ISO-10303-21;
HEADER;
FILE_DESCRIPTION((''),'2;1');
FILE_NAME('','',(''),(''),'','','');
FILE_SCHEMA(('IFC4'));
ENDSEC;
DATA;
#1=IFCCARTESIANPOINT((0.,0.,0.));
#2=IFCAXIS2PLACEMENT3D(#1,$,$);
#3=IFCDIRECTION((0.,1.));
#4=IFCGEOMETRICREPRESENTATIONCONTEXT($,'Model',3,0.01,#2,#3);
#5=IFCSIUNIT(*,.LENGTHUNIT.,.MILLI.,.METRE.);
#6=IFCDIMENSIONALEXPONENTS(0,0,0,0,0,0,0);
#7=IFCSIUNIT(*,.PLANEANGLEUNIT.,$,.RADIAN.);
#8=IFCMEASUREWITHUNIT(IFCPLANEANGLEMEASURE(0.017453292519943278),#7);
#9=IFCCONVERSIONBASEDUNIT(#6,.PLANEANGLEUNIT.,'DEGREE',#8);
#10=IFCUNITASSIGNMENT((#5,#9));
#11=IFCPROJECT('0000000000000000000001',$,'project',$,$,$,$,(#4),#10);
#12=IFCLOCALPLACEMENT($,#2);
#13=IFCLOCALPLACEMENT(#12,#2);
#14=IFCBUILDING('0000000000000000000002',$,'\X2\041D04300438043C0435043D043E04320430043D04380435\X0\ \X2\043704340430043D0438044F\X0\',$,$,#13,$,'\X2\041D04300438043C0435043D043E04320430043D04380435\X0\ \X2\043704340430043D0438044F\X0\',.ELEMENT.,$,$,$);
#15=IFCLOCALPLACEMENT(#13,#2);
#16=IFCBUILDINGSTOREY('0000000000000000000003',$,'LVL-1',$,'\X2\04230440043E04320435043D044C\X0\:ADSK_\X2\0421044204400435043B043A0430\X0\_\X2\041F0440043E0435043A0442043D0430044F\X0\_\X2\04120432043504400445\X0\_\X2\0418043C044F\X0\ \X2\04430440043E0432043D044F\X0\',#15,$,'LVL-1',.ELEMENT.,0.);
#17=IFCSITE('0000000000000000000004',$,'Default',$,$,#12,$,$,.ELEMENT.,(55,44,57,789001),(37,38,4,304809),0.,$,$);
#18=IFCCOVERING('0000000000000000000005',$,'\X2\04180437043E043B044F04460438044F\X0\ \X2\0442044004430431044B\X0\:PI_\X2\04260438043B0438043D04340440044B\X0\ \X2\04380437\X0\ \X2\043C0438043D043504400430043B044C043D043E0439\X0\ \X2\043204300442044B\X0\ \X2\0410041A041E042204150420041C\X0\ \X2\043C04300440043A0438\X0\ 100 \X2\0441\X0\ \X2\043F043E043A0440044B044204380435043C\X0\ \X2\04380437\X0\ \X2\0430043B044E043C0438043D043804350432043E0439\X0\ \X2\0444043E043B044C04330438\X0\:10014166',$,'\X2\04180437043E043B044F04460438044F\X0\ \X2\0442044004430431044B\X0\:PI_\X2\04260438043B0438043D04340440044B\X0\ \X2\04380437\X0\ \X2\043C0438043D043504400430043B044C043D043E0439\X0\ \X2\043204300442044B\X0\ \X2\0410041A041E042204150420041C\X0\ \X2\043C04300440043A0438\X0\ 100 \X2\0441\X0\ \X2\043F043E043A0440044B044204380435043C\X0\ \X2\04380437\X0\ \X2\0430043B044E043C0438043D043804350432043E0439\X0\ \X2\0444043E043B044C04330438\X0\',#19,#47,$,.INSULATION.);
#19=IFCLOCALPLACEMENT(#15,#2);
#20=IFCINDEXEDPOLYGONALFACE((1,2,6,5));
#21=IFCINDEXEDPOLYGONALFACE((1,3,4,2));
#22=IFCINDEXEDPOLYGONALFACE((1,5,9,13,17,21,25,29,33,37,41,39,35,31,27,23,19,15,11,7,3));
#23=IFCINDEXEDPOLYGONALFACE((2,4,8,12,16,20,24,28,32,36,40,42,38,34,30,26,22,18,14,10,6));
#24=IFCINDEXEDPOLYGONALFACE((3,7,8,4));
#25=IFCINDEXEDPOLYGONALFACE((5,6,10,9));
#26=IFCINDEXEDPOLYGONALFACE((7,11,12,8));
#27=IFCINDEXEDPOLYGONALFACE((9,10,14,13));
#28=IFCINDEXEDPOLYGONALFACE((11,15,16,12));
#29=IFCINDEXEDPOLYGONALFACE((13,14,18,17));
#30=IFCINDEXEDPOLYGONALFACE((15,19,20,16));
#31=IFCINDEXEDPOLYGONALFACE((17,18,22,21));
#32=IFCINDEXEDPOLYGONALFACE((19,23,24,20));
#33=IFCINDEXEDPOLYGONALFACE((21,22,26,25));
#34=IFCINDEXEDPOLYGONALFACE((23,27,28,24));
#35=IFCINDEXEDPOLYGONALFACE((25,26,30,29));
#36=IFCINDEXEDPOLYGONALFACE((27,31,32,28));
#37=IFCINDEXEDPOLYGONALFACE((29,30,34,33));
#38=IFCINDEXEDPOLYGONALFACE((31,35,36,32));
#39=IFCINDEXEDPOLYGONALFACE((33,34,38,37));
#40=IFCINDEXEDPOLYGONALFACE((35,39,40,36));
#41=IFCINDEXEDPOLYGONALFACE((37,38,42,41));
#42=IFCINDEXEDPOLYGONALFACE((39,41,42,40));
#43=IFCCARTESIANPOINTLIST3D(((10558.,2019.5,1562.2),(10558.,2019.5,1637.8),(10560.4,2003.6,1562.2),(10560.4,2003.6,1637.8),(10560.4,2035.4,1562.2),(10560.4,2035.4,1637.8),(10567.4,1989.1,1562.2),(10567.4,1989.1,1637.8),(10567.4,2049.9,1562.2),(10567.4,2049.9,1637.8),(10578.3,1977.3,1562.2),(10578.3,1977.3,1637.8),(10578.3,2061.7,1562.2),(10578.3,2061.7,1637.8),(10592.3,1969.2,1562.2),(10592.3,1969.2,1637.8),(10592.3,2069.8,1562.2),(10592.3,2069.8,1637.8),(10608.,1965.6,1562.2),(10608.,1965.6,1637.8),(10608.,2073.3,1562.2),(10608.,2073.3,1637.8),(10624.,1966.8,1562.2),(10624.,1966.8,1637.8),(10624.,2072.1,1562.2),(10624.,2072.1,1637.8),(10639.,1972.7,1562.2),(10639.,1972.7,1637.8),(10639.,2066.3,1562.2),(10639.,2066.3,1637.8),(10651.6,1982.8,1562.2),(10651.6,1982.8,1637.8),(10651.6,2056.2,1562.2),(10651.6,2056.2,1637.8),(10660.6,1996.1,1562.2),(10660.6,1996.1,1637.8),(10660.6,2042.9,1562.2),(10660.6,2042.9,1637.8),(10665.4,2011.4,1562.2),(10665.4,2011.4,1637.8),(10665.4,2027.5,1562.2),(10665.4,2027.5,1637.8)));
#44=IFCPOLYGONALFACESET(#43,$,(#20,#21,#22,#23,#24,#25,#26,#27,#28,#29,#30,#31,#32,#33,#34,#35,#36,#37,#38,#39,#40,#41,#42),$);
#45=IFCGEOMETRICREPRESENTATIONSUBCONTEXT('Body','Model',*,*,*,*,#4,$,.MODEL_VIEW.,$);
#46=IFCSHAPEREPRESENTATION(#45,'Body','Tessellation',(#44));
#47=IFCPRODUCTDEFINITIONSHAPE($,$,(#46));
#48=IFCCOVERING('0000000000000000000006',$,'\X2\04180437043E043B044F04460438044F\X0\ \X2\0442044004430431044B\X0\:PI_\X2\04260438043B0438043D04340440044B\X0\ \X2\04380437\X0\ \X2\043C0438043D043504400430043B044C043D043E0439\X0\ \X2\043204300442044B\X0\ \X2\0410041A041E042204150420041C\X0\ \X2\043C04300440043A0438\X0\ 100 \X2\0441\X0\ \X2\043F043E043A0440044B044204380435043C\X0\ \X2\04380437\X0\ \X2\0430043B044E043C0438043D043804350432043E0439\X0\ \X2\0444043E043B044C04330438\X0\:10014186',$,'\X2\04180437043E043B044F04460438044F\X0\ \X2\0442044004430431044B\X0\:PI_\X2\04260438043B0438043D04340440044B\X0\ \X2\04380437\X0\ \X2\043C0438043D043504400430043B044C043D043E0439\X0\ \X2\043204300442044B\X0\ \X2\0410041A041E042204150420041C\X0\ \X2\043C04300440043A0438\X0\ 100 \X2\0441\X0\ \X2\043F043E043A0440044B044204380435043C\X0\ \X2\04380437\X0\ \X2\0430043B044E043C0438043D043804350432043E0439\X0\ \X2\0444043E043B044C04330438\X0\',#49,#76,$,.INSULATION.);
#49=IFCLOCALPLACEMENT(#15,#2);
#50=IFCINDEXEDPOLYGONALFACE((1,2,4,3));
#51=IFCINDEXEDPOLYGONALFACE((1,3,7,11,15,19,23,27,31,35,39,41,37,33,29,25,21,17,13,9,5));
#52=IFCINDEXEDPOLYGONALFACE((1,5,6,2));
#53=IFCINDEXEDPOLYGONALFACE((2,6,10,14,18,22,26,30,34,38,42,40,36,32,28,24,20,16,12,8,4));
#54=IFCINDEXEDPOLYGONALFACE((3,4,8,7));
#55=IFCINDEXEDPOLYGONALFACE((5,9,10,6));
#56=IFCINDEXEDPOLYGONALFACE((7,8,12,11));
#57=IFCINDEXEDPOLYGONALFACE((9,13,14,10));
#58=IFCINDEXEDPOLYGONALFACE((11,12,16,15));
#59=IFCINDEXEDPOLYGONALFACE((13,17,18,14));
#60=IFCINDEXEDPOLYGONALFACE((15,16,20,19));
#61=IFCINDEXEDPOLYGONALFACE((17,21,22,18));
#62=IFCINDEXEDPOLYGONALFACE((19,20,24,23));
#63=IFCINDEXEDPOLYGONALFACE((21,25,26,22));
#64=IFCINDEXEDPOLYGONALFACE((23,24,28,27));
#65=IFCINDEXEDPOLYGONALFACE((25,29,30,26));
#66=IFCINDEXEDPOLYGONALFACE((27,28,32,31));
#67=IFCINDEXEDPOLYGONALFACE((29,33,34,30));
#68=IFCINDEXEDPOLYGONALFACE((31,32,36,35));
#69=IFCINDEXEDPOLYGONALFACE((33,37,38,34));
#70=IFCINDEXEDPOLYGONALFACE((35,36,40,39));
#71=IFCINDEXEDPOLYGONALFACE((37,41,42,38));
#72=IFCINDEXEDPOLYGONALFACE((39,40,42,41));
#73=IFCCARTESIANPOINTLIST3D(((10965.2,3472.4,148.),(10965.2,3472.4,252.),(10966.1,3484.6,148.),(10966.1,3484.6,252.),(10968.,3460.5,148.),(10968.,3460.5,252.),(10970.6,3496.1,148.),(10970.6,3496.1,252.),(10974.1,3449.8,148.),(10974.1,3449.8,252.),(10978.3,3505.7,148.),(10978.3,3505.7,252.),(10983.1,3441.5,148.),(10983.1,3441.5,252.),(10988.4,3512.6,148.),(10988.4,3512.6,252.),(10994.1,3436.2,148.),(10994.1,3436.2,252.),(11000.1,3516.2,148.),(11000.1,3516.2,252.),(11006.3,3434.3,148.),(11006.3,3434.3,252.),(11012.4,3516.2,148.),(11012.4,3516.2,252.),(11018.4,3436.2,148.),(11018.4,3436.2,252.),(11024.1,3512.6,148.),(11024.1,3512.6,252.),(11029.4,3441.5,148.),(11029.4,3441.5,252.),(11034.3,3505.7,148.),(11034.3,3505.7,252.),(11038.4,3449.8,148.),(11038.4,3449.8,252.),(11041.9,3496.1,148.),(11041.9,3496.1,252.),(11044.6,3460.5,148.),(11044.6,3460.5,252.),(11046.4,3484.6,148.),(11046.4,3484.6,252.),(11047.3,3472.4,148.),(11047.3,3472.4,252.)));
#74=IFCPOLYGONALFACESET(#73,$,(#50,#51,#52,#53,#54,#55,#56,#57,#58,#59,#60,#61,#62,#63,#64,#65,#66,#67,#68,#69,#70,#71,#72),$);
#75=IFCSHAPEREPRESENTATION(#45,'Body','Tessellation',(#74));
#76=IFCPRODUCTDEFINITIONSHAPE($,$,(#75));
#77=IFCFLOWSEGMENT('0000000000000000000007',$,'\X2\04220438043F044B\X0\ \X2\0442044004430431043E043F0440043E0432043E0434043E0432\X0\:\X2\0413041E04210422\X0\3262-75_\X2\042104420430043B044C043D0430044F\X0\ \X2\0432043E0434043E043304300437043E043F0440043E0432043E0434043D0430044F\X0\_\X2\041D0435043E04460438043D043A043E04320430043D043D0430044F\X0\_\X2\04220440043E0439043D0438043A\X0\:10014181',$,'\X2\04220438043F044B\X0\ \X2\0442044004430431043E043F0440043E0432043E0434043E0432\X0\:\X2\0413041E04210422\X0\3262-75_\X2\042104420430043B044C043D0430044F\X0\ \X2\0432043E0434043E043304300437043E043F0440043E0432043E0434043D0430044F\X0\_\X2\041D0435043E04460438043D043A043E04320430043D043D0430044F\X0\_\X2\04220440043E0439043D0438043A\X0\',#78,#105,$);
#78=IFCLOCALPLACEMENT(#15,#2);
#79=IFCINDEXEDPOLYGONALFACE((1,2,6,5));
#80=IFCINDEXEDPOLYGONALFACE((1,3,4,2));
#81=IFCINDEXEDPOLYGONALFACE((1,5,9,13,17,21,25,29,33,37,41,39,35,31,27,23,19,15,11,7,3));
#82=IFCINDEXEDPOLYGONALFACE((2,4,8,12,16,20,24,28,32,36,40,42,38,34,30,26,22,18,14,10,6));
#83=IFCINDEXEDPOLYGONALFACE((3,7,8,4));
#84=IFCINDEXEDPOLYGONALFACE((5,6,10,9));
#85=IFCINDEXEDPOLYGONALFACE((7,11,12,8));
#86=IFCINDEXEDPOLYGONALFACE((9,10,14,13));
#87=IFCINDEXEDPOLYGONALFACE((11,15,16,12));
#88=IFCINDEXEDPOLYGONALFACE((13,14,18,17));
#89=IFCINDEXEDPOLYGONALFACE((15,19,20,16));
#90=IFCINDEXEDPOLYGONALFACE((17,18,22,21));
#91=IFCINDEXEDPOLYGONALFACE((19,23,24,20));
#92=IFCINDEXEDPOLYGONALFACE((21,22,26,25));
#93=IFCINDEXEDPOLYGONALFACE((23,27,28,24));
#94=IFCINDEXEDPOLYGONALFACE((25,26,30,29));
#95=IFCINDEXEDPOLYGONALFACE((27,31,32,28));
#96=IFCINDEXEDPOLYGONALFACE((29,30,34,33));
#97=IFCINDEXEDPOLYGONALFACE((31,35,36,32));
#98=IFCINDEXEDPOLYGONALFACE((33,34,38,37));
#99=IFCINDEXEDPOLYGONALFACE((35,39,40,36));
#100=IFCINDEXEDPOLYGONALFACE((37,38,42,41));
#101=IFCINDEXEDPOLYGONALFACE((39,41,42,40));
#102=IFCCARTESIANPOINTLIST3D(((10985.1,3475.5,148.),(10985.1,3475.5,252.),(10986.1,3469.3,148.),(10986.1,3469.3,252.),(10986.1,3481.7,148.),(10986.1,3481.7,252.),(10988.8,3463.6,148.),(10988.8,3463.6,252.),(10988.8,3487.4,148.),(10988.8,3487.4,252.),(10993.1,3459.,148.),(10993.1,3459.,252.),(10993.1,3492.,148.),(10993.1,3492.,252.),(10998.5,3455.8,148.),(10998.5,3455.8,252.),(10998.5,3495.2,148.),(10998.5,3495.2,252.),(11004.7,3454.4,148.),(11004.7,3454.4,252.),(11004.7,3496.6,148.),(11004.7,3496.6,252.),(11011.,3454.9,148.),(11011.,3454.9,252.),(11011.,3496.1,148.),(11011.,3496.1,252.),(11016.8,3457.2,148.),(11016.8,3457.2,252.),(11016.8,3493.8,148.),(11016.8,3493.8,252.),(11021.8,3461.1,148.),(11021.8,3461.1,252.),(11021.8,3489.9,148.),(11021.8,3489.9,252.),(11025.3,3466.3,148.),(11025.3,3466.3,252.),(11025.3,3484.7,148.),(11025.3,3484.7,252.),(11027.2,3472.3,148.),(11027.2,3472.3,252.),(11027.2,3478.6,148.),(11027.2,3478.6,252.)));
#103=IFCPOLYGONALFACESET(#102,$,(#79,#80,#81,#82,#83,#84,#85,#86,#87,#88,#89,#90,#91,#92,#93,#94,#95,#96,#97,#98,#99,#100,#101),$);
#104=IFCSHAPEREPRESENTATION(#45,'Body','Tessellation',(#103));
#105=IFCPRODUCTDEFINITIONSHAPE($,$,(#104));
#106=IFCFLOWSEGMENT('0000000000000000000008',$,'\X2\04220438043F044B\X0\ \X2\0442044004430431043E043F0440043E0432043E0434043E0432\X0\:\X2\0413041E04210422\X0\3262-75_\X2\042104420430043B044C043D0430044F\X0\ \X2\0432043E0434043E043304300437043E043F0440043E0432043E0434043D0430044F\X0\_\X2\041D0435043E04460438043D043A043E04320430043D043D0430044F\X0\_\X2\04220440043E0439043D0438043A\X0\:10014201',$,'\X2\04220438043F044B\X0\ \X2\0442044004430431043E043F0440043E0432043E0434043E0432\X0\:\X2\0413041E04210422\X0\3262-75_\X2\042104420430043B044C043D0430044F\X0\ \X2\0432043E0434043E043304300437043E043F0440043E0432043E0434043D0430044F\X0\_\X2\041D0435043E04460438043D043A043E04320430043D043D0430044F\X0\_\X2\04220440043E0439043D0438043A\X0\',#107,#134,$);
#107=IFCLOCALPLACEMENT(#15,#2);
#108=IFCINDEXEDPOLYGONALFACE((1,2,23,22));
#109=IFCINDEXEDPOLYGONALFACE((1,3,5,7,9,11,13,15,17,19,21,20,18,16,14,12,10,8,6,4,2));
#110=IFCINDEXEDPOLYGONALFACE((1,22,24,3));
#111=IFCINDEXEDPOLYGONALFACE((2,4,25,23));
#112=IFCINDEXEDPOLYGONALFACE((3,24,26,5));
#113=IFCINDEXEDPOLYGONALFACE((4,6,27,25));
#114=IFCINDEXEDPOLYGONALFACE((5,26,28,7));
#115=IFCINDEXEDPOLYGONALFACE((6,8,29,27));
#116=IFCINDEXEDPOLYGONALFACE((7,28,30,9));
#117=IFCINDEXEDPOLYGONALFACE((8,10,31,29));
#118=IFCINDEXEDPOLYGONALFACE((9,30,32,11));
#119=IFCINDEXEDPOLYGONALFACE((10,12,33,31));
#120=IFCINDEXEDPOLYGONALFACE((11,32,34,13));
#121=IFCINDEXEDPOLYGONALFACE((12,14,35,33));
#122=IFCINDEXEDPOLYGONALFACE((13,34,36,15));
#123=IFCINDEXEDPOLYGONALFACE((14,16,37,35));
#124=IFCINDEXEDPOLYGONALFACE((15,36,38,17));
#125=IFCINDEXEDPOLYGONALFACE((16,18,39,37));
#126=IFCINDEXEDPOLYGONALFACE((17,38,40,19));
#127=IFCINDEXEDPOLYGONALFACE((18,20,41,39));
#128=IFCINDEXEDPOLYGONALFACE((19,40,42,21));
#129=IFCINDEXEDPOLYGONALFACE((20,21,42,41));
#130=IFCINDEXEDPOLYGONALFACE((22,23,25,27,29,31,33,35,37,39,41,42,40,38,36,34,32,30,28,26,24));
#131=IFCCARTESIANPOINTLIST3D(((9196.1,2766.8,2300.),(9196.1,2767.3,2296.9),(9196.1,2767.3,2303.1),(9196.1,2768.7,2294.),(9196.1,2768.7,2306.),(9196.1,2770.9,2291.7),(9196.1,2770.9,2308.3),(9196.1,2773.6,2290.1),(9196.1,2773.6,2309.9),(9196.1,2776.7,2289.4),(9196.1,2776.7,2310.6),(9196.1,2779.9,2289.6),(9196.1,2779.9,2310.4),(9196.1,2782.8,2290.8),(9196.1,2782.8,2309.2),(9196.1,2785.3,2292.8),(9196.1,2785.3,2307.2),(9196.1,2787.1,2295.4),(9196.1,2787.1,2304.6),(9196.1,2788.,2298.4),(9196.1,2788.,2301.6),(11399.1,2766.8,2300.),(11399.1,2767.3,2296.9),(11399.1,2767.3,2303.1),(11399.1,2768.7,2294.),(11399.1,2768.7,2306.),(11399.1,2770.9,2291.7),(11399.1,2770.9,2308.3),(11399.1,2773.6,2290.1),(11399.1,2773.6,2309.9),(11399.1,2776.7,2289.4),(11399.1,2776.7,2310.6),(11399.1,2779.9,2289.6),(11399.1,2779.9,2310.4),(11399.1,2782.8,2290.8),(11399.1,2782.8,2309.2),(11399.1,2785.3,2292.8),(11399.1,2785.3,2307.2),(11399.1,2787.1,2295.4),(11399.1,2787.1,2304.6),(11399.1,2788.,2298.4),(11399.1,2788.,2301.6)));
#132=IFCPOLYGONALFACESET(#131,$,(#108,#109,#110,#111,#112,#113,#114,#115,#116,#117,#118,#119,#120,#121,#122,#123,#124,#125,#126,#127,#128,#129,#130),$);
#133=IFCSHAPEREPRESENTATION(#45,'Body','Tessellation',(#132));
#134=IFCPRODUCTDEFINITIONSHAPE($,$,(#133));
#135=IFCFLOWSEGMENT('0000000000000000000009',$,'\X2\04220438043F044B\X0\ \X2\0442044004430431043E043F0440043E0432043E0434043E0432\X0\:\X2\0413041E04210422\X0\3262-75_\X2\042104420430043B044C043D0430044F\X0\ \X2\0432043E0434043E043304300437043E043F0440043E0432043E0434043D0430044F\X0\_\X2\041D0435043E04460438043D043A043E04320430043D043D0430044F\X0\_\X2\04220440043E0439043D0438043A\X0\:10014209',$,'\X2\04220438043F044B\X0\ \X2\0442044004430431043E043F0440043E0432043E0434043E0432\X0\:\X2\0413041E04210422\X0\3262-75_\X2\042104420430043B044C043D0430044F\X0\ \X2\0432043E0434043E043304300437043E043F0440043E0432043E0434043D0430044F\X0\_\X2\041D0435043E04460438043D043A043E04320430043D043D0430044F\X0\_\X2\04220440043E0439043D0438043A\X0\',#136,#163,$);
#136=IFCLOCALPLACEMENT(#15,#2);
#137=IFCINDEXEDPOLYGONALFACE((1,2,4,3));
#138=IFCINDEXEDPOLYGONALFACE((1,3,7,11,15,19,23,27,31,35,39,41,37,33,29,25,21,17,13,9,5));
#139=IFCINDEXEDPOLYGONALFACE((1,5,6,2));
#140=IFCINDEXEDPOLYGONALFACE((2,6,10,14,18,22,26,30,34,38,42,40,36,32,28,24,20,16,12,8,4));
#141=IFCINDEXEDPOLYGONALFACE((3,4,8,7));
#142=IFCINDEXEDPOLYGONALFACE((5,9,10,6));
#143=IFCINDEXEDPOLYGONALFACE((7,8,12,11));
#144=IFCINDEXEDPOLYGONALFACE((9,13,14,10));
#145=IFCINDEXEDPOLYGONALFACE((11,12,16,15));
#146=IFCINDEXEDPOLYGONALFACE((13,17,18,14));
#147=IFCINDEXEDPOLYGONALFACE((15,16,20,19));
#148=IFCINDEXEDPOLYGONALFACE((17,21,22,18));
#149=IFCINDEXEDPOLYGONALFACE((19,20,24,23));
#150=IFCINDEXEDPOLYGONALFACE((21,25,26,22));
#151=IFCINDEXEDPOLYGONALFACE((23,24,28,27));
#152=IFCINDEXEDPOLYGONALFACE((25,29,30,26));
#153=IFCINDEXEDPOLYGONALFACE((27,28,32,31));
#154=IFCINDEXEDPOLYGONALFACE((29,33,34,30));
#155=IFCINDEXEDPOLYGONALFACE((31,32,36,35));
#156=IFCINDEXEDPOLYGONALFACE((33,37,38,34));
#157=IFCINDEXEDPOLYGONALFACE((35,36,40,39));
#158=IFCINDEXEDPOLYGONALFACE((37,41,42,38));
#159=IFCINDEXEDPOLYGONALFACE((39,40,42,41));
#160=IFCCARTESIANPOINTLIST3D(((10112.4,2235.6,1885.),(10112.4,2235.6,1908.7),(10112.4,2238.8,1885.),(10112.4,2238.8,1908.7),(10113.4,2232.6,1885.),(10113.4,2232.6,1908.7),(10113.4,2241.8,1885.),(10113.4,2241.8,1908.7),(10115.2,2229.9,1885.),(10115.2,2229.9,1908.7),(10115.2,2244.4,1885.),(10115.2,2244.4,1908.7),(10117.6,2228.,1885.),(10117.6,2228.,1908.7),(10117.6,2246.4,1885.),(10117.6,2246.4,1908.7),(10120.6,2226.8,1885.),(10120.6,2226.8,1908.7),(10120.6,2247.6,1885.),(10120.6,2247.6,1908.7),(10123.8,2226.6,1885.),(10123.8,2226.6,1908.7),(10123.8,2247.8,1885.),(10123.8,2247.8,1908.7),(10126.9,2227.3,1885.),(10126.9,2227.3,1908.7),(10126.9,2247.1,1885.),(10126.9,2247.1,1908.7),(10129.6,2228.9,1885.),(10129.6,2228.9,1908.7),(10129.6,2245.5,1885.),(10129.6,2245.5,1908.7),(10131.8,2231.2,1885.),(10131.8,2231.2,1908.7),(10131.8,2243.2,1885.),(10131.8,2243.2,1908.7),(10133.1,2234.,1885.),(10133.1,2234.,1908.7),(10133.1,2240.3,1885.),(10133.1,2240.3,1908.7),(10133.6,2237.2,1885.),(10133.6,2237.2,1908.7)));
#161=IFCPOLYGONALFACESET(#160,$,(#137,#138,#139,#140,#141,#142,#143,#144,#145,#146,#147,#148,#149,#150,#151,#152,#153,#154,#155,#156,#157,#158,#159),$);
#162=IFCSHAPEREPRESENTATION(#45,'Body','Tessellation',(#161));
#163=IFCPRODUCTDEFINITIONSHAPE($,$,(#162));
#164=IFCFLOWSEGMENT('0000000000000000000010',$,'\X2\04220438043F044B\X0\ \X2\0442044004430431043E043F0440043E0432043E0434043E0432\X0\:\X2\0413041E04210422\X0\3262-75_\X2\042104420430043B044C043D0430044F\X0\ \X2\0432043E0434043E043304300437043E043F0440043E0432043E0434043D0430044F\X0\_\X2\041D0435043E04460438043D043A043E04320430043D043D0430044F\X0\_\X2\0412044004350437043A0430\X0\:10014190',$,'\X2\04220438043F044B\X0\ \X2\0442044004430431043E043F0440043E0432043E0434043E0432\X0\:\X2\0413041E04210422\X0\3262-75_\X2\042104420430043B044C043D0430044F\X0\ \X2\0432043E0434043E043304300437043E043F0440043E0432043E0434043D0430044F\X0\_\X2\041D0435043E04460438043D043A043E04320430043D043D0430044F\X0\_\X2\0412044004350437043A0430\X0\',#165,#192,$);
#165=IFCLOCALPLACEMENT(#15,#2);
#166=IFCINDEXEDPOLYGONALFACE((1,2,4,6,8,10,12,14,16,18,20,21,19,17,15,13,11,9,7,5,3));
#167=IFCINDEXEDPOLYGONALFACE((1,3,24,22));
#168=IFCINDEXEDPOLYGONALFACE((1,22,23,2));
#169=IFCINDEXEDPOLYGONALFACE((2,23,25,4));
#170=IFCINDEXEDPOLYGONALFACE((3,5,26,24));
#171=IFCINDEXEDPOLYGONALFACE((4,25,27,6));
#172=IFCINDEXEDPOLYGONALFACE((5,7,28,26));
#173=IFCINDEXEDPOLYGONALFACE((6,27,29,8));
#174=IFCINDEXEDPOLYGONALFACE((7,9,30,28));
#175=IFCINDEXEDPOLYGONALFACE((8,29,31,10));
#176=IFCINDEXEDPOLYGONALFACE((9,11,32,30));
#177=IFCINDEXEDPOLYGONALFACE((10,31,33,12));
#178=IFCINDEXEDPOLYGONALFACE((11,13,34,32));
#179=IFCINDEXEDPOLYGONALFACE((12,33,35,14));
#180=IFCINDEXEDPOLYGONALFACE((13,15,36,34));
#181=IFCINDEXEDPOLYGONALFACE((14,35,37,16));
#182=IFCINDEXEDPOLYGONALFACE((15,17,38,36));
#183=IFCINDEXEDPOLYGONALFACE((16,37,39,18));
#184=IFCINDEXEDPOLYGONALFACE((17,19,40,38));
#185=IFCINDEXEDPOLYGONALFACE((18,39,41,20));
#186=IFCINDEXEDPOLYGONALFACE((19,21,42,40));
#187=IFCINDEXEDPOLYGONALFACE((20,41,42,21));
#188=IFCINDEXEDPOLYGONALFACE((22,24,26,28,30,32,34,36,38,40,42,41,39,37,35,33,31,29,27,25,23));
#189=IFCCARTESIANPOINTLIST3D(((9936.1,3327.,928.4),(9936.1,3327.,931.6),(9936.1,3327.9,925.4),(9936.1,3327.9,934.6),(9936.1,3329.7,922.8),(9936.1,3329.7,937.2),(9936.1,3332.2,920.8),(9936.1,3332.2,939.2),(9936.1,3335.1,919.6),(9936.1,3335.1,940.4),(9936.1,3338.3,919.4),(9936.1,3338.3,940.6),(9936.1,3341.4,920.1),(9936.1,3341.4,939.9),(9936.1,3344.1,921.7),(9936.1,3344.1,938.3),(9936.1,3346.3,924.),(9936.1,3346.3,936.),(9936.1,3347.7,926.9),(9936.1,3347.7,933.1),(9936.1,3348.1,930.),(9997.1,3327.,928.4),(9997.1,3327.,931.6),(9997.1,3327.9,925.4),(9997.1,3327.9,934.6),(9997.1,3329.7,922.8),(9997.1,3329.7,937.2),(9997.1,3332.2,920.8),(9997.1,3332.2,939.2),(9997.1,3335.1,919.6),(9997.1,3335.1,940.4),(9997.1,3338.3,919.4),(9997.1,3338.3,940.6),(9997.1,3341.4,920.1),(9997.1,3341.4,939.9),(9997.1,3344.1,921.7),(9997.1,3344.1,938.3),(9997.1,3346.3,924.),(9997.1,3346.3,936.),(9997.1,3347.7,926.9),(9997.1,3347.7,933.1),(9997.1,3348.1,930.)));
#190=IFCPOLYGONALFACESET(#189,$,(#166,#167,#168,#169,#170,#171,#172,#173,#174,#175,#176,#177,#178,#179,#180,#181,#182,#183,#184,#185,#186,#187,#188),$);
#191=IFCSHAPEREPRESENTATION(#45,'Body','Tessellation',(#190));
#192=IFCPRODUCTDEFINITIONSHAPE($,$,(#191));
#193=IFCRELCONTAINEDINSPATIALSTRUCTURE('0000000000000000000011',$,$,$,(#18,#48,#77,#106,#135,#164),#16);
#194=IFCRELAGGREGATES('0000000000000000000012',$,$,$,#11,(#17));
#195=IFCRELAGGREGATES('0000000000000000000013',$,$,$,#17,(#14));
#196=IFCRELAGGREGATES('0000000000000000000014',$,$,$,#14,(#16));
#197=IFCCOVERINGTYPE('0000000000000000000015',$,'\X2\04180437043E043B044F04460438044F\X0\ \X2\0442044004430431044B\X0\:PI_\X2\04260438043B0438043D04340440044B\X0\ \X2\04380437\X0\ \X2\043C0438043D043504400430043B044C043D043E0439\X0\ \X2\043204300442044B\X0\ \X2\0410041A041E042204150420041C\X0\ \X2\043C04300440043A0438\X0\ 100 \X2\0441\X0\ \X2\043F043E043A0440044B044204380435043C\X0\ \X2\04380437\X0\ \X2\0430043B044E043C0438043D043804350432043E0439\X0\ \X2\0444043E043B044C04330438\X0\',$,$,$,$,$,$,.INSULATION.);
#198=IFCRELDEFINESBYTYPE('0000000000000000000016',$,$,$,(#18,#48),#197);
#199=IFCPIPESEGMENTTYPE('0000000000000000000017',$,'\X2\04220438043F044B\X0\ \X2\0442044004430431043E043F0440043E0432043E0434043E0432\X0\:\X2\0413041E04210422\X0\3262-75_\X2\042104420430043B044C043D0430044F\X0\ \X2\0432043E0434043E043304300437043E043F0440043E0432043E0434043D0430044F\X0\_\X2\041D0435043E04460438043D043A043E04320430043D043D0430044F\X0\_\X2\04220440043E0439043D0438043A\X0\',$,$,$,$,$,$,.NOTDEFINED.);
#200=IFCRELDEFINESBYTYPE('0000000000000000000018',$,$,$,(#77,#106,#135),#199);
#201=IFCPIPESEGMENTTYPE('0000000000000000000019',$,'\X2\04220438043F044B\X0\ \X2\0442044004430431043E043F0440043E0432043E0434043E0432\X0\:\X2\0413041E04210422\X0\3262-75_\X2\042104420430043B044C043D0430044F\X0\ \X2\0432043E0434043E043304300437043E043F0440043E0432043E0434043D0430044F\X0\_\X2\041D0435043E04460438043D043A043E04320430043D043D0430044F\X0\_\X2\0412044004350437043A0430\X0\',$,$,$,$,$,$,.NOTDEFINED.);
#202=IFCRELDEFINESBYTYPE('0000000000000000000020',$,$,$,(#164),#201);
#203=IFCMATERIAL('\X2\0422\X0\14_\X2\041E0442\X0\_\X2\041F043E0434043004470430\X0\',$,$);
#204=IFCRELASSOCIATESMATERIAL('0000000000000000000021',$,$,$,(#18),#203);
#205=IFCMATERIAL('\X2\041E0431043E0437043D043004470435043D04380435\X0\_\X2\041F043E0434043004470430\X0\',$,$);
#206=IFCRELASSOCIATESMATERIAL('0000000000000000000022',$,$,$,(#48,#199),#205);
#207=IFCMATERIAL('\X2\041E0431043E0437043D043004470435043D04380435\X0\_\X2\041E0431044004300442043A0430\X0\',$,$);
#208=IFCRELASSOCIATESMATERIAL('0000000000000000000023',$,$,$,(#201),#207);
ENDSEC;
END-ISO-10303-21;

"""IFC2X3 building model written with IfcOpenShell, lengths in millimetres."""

from ifc_helpers import new_model, entity, si_unit, converted_unit, direction, frame, frame_2d, origin, origin_2d_with_axis, place, context, subcontext, project, spatial, circle, extrude, material, type_object, element, save


model = new_model("IFC2X3")

# Units and contexts
model_context = context("Model", 3, precision=0.01, world=origin(), true_north=direction((0.0, 1.0)))
body_context = subcontext(model_context, "Body", "Model", "MODEL_VIEW")
ifc_project = project(units=[si_unit("LENGTHUNIT", "METRE", prefix="MILLI"), converted_unit("PLANEANGLEUNIT", "DEGREE", entity("IfcPlaneAngleMeasure", 0.017453292519943278), si_unit("PLANEANGLEUNIT", "RADIAN"), dimensions=[0, 0, 0, 0, 0, 0, 0])], contexts=[model_context])

# Site, building, storey
site_placement = place(None, origin())
site = spatial("IfcSite", under=ifc_project, at=site_placement, Name="Default", CompositionType="ELEMENT", RefLatitude=(55, 44, 57, 789001), RefLongitude=(37, 38, 4, 304809), RefElevation=0.0)
building_placement = place(site_placement, origin())
building = spatial("IfcBuilding", under=site, at=building_placement, Name="Наименование здания", LongName="Наименование здания", CompositionType="ELEMENT")
storey_placement = place(building_placement, origin())
storey = spatial("IfcBuildingStorey", under=building, at=storey_placement, Name="LVL-1", ObjectType="Уровень:ADSK_Стрелка_Проектная_Вверх_Имя уровня", LongName="LVL-1", CompositionType="ELEMENT", Elevation=0.0)

# Coverings
ifc_material_1 = material(Name="Т14_От_Подача")
covering_type_1 = type_object("IfcCoveringType", Name="Изоляция трубы:PI_Цилиндры из минеральной ваты АКОТЕРМ марки 100 с покрытием из алюминиевой фольги", PredefinedType="INSULATION")
covering_1_placement = place(storey_placement, origin())
element("IfcCovering", 1, at=covering_1_placement, inside=storey, type_object=covering_type_1, material=ifc_material_1, Name="Изоляция трубы:PI_Цилиндры из минеральной ваты АКОТЕРМ марки 100 с покрытием из алюминиевой фольги:10014166", ObjectType="Изоляция трубы:PI_Цилиндры из минеральной ваты АКОТЕРМ марки 100 с покрытием из алюминиевой фольги", PredefinedType="INSULATION", context=body_context, shape_type="SweptSolid", body=[
    extrude(circle(Radius=54.0, at=frame_2d((0.0, 0.0), x_axis=(1.0, 0.0))), frame((10612.0, 2019.5, 1562.2), z_axis=(0.0, 0.0, 1.0), x_axis=(-1.0, 0.0, 0.0)), (0.0, 0.0, 1.0), 75.5),
])
ifc_material_2 = material(Name="Обозначение_Подача")
covering_2_placement = place(storey_placement, origin())
element("IfcCovering", 2, at=covering_2_placement, inside=storey, type_object=covering_type_1, material=ifc_material_2, Name="Изоляция трубы:PI_Цилиндры из минеральной ваты АКОТЕРМ марки 100 с покрытием из алюминиевой фольги:10014186", ObjectType="Изоляция трубы:PI_Цилиндры из минеральной ваты АКОТЕРМ марки 100 с покрытием из алюминиевой фольги", PredefinedType="INSULATION", context=body_context, shape_type="SweptSolid", body=[
    extrude(circle(Radius=41.1, at=origin_2d_with_axis()), frame((11006.3, 3475.5, 148.0), z_axis=(0.0, 0.0, 1.0), x_axis=(0.0, -1.0, 0.0)), (0.0, 0.0, 1.0), 104.0),
])

# Flow segments
pipe_segment_type_1 = type_object("IfcPipeSegmentType", Name="Типы трубопроводов:ГОСТ3262-75_Стальная водогазопроводная_Неоцинкованная_Тройник", PredefinedType="NOTDEFINED", material=ifc_material_2)
flow_segment_1_placement = place(storey_placement, origin())
element("IfcFlowSegment", 3, at=flow_segment_1_placement, inside=storey, type_object=pipe_segment_type_1, Name="Типы трубопроводов:ГОСТ3262-75_Стальная водогазопроводная_Неоцинкованная_Тройник:10014181", ObjectType="Типы трубопроводов:ГОСТ3262-75_Стальная водогазопроводная_Неоцинкованная_Тройник", context=body_context, shape_type="SweptSolid", body=[
    extrude(circle(Radius=21.1, at=frame_2d((0.0, 0.0), x_axis=(1.0, 0.0))), frame((11006.3, 3475.5, 148.0), z_axis=(0.0, 0.0, 1.0), x_axis=(-1.0, 0.0, 0.0)), (0.0, 0.0, 1.0), 104.0),
])
flow_segment_2_placement = place(storey_placement, origin())
element("IfcFlowSegment", 4, at=flow_segment_2_placement, inside=storey, type_object=pipe_segment_type_1, Name="Типы трубопроводов:ГОСТ3262-75_Стальная водогазопроводная_Неоцинкованная_Тройник:10014201", ObjectType="Типы трубопроводов:ГОСТ3262-75_Стальная водогазопроводная_Неоцинкованная_Тройник", context=body_context, shape_type="SweptSolid", body=[
    extrude(circle(Radius=10.7, at=origin_2d_with_axis()), frame((9196.1, 2777.5, 2300.0), z_axis=(1.0, 0.0, 0.0), x_axis=(0.0, -1.0, 0.0)), (0.0, 0.0, 1.0), 2203.0),
])
flow_segment_3_placement = place(storey_placement, origin())
element("IfcFlowSegment", 5, at=flow_segment_3_placement, inside=storey, type_object=pipe_segment_type_1, Name="Типы трубопроводов:ГОСТ3262-75_Стальная водогазопроводная_Неоцинкованная_Тройник:10014209", ObjectType="Типы трубопроводов:ГОСТ3262-75_Стальная водогазопроводная_Неоцинкованная_Тройник", context=body_context, shape_type="SweptSolid", body=[
    extrude(circle(Radius=10.7, at=origin_2d_with_axis()), frame((10123.0, 2237.2, 1885.0)), (0.0, 0.0, 1.0), 23.7),
])
ifc_material_3 = material(Name="Обозначение_Обратка")
pipe_segment_type_2 = type_object("IfcPipeSegmentType", Name="Типы трубопроводов:ГОСТ3262-75_Стальная водогазопроводная_Неоцинкованная_Врезка", PredefinedType="NOTDEFINED", material=ifc_material_3)
flow_segment_4_placement = place(storey_placement, origin())
element("IfcFlowSegment", 6, at=flow_segment_4_placement, inside=storey, type_object=pipe_segment_type_2, Name="Типы трубопроводов:ГОСТ3262-75_Стальная водогазопроводная_Неоцинкованная_Врезка:10014190", ObjectType="Типы трубопроводов:ГОСТ3262-75_Стальная водогазопроводная_Неоцинкованная_Врезка", context=body_context, shape_type="SweptSolid", body=[
    extrude(circle(Radius=10.7, at=origin_2d_with_axis()), frame((9936.1, 3337.5, 930.0), z_axis=(1.0, 0.0, 0.0), x_axis=(0.0, 1.0, 0.0)), (0.0, 0.0, 1.0), 61.0),
])

save(model, "model.ifc")
